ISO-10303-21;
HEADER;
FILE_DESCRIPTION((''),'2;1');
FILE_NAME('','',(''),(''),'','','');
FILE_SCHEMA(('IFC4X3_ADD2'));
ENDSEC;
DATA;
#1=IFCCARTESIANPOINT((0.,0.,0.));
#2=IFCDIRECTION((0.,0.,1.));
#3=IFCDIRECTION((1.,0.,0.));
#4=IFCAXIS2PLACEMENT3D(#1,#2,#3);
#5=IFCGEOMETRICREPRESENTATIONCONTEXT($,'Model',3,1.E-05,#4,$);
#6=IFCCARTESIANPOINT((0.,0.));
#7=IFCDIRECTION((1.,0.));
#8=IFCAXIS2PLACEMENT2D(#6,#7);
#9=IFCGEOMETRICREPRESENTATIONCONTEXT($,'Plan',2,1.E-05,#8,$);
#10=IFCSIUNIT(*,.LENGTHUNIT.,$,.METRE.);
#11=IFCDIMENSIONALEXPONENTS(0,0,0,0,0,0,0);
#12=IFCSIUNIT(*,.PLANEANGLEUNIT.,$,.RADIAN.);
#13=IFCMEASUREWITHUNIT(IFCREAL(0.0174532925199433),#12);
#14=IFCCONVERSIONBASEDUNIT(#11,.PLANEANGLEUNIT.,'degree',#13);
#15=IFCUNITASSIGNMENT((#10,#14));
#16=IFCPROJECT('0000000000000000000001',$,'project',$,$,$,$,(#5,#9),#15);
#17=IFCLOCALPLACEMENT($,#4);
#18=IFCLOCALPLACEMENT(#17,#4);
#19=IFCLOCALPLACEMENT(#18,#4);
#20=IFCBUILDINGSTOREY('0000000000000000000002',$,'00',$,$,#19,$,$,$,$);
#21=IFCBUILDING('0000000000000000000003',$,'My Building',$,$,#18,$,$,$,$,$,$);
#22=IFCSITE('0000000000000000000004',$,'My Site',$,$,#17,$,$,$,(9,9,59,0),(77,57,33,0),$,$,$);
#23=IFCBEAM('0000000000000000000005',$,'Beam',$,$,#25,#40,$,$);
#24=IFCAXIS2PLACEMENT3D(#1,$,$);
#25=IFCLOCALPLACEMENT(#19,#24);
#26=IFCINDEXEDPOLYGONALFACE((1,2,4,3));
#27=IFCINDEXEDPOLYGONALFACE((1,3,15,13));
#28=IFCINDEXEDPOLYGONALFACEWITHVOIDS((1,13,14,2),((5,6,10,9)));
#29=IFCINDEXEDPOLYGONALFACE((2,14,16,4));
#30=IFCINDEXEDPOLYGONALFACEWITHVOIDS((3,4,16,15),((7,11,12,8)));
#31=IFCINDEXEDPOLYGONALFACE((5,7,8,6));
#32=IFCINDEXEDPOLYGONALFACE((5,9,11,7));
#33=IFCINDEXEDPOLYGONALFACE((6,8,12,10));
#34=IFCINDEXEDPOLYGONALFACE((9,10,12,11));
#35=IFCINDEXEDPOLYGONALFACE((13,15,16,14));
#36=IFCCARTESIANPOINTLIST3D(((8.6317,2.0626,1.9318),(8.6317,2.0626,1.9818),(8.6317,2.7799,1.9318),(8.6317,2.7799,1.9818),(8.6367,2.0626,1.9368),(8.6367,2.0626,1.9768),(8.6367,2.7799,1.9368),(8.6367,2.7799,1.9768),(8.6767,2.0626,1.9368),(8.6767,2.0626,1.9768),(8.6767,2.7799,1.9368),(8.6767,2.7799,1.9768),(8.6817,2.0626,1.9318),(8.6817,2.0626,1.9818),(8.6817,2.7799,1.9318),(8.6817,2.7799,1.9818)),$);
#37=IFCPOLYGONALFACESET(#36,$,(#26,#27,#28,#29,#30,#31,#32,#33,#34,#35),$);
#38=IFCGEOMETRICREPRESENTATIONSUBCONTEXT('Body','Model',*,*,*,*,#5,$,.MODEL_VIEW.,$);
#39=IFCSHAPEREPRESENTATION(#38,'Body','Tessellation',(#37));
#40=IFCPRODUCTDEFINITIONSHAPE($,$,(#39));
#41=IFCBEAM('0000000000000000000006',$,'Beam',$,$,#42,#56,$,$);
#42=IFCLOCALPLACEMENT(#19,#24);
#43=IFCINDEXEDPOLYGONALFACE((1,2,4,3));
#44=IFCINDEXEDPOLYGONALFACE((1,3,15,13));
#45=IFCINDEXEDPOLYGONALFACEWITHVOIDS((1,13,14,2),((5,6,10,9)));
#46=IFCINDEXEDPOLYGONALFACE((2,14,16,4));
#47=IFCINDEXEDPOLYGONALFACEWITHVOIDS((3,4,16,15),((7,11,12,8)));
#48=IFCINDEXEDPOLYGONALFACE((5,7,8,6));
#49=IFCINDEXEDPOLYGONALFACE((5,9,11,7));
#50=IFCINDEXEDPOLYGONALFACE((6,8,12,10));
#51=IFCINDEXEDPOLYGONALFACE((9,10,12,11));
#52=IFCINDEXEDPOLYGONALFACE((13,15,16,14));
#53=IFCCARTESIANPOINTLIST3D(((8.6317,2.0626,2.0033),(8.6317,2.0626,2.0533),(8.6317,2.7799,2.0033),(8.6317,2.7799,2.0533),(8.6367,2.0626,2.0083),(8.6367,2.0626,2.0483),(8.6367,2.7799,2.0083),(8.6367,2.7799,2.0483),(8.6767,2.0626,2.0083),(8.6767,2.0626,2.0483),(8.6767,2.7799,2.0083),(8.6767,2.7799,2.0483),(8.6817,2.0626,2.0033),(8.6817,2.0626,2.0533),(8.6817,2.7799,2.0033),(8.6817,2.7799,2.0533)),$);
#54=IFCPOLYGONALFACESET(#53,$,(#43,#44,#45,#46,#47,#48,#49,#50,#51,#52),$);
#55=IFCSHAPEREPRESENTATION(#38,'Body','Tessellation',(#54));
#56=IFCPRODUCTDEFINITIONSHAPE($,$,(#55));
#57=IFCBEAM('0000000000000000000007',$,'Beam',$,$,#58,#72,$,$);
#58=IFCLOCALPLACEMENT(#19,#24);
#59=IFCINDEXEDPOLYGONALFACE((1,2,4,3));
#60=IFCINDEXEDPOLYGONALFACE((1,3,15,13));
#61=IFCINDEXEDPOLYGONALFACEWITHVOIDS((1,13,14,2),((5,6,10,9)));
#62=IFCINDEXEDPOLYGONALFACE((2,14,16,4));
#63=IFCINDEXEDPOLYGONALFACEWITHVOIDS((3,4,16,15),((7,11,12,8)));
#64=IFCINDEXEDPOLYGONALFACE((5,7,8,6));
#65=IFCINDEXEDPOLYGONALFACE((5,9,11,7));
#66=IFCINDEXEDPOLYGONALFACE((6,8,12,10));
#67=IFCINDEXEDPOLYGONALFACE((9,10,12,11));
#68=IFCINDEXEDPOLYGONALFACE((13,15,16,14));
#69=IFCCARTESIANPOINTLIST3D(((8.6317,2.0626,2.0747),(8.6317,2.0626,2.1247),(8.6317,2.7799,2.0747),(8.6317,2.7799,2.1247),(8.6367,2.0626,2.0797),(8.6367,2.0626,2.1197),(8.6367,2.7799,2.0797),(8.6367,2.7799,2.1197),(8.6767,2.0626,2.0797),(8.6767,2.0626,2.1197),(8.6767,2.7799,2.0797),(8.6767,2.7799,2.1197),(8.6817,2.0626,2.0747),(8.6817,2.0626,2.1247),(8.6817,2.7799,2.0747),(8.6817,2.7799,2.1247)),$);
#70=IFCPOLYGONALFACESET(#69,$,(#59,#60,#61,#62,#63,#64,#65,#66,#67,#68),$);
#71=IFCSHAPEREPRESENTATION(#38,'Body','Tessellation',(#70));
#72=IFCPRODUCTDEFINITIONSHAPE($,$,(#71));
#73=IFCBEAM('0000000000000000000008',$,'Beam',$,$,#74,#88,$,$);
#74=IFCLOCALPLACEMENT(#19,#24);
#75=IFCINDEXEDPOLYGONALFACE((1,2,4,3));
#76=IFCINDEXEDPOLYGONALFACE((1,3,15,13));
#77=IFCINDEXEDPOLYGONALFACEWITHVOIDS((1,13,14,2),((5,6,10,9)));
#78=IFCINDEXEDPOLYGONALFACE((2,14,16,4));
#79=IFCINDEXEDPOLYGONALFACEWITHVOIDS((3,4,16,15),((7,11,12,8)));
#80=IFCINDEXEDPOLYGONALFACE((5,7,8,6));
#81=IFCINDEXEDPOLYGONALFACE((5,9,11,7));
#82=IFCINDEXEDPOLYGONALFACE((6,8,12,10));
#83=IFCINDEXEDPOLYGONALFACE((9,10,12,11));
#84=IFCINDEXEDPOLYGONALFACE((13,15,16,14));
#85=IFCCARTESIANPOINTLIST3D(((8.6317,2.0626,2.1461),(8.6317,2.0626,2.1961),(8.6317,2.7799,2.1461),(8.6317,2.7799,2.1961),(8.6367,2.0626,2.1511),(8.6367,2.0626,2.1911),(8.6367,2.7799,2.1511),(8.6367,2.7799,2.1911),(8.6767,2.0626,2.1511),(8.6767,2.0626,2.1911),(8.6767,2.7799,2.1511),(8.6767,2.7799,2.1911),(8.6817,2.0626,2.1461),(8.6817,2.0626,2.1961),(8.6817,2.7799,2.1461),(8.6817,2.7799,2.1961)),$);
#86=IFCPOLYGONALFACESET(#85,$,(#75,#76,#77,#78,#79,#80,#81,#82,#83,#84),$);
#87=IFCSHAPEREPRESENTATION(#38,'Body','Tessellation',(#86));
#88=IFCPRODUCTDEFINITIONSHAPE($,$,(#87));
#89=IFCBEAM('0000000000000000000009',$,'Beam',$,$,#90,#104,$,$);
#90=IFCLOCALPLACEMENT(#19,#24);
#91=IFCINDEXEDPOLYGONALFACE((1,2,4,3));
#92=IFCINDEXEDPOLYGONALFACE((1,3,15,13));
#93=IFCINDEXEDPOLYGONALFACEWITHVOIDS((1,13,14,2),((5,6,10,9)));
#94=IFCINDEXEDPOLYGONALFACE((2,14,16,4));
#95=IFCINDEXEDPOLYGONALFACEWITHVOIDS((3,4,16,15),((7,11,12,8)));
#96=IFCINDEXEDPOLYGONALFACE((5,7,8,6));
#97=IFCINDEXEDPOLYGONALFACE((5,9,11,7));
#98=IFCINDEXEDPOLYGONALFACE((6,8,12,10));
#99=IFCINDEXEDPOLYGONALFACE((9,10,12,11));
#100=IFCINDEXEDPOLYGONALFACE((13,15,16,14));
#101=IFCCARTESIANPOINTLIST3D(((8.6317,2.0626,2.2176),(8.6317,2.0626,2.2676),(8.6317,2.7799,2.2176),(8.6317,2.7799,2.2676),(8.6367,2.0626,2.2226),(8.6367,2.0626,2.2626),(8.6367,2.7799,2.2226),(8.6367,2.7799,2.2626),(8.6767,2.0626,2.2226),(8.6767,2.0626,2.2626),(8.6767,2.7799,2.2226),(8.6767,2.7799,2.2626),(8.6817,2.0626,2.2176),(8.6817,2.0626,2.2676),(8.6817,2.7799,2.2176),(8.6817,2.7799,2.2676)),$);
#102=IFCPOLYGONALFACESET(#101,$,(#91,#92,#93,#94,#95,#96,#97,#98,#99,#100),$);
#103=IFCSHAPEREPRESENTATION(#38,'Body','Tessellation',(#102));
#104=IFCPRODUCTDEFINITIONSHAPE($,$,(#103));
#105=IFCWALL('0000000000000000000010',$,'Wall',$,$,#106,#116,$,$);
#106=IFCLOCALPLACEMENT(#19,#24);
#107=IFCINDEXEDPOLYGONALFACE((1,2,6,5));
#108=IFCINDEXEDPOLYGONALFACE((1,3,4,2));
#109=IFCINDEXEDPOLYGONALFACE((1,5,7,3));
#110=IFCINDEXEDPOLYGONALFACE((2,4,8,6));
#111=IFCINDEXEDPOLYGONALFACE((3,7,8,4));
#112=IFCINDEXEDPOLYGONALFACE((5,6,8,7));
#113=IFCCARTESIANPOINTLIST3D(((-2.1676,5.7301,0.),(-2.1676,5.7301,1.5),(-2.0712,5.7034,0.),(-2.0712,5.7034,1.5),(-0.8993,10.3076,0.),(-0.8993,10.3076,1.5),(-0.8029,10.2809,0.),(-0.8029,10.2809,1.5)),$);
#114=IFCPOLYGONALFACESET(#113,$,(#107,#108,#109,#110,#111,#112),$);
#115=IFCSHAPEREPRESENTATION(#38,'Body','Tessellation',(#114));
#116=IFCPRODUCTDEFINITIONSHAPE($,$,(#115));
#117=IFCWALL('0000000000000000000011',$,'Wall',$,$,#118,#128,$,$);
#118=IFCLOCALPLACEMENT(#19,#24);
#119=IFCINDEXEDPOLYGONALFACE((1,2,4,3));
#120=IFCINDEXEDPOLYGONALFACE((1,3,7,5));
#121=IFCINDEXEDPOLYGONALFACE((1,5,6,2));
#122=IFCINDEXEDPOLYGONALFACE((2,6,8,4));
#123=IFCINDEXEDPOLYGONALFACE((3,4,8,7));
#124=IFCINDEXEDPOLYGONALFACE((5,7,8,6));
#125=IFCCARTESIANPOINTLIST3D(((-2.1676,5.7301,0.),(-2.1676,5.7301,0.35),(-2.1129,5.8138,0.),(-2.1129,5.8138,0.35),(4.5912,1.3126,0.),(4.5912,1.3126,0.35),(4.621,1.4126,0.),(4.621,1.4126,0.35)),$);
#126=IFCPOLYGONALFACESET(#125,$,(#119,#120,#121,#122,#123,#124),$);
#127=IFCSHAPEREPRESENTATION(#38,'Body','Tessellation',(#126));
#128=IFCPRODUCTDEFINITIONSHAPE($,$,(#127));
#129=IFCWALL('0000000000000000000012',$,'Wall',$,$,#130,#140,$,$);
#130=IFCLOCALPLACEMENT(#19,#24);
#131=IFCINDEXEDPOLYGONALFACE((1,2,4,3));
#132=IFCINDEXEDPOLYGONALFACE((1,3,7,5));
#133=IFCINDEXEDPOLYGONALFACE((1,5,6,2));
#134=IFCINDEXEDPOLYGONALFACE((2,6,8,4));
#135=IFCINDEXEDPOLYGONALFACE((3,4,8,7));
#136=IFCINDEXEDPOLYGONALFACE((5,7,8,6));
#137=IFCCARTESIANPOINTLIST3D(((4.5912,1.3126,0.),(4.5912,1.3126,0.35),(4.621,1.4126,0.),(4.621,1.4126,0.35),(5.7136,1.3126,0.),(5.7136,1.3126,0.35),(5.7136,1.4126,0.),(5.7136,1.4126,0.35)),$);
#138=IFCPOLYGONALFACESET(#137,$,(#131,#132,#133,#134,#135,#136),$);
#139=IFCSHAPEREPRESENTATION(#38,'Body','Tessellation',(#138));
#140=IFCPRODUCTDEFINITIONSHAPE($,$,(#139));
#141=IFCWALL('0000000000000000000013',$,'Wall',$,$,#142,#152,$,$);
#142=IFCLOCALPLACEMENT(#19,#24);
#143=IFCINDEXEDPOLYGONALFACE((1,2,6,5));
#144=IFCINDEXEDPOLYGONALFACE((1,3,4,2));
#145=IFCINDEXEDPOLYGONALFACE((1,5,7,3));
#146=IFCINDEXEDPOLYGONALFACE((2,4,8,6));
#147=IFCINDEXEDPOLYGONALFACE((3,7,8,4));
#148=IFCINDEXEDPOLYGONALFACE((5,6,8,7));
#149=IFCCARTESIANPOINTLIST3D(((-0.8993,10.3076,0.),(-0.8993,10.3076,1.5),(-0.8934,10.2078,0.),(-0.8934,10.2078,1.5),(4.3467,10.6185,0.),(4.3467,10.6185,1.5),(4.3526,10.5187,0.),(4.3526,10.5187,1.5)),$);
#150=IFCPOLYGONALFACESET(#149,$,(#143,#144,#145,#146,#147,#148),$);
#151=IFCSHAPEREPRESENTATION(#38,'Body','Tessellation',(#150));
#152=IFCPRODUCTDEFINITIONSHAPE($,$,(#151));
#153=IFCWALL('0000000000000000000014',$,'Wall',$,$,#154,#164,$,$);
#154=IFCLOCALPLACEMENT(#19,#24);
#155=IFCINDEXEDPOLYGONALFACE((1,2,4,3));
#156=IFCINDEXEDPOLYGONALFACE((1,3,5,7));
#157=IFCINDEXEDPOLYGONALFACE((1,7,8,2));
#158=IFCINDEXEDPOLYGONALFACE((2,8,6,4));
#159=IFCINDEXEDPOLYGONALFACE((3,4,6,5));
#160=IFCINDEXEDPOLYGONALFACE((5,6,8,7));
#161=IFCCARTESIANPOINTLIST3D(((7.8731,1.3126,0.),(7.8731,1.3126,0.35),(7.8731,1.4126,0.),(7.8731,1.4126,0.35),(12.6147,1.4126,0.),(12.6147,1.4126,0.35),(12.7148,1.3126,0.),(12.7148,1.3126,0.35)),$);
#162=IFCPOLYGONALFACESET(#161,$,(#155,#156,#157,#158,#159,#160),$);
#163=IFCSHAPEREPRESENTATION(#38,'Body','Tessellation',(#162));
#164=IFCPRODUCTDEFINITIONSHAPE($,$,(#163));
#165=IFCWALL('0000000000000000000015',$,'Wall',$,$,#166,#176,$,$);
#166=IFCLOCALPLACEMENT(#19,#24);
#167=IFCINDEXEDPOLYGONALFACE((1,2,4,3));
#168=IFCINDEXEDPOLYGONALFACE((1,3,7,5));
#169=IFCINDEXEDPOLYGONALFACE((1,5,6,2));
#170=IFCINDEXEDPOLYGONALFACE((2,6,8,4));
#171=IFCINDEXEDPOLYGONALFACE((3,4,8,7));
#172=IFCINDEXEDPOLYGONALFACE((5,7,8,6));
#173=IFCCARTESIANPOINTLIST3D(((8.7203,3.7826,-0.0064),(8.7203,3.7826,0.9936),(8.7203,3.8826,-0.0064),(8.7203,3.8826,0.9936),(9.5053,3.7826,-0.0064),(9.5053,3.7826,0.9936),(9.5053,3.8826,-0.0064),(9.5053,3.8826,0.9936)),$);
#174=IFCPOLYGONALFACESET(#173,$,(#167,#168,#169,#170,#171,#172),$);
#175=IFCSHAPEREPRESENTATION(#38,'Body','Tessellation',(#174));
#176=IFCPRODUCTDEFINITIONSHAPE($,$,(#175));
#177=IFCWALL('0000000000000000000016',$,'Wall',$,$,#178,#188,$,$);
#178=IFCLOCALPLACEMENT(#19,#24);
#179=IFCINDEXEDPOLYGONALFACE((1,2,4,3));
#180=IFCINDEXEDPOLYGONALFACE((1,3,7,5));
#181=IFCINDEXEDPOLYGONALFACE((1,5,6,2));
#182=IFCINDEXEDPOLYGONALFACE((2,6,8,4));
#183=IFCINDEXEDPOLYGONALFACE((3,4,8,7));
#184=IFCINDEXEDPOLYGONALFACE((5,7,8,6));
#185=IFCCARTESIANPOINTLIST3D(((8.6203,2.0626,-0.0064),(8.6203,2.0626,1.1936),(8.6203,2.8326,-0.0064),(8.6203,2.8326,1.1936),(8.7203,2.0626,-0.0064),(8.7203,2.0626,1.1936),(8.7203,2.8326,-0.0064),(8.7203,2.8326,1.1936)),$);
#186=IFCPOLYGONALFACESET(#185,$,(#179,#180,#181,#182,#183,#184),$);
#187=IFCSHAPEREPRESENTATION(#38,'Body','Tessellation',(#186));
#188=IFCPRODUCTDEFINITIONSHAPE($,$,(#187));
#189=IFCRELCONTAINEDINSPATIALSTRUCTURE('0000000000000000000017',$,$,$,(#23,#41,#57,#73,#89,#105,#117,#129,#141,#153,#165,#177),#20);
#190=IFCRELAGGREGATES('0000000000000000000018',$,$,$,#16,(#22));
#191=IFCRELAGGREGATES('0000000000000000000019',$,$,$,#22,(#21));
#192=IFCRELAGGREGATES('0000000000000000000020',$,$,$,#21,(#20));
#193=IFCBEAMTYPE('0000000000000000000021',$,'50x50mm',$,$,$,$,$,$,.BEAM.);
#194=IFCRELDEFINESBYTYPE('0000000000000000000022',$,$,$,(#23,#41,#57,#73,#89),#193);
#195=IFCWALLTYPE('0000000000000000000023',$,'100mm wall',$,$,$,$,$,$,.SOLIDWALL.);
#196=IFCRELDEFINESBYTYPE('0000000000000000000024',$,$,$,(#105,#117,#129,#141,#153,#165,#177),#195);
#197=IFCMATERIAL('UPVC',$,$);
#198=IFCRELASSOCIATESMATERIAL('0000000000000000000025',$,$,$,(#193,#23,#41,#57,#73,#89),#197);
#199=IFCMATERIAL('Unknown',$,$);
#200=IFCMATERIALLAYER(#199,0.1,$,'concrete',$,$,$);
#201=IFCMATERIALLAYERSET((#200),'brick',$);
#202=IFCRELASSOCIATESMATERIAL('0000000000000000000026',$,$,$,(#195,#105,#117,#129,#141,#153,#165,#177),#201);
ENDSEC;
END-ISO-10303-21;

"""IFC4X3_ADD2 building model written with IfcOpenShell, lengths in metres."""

from ifc_helpers import new_model, entity, si_unit, converted_unit, frame, origin_with_axes, origin_2d_with_axis, place, context, subcontext, project, spatial, line, indexed_curve, hollow_rectangle, outline, extrude, material, layer, layer_set, layer_usage, material_profile, profile_set, profile_usage, type_object, element, save


model = new_model("IFC4X3_ADD2")

# Units and contexts
model_context = context("Model", 3, precision=1e-05, world=origin_with_axes())
plan_context = context("Plan", 2, precision=1e-05, world=origin_2d_with_axis())
body_context = subcontext(model_context, "Body", "Model", "MODEL_VIEW")
ifc_project = project(units=[si_unit("LENGTHUNIT", "METRE"), converted_unit("PLANEANGLEUNIT", "degree", entity("IfcReal", 0.0174532925199433), si_unit("PLANEANGLEUNIT", "RADIAN"), dimensions=[0, 0, 0, 0, 0, 0, 0])], contexts=[model_context, plan_context])

# Site, building, storey
site_placement = place(None, origin_with_axes())
site = spatial("IfcSite", under=ifc_project, at=site_placement, Name="My Site", RefLatitude=(9, 9, 59, 0), RefLongitude=(77, 57, 33, 0))
building_placement = place(site_placement, origin_with_axes())
building = spatial("IfcBuilding", under=site, at=building_placement, Name="My Building")
storey_placement = place(building_placement, origin_with_axes())
storey = spatial("IfcBuildingStorey", under=building, at=storey_placement, Name="00")

# Beams
ifc_material_1 = material(Name="UPVC")
ifc_material_profile_1 = material_profile(ifc_material_1, hollow_rectangle(XDim=0.05, YDim=0.05, WallThickness=0.005))
ifc_profile_set_1 = profile_set([ifc_material_profile_1])
beam_type = type_object("IfcBeamType", Name="50x50mm", PredefinedType="BEAM", material=ifc_profile_set_1)
ifc_profile_usage_1 = profile_usage(ifc_profile_set_1, cardinal=5)
beam_1_placement = place(storey_placement, frame((8.6567, 2.0626, 1.9568), z_axis=(0.0, 1.0, 0.000001), x_axis=(-1.0, 0.0, 0.0)))
element("IfcBeam", 1, at=beam_1_placement, inside=storey, type_object=beam_type, material=ifc_profile_usage_1, Name="Beam", context=body_context, shape_type="SweptSolid", body=[
    extrude(hollow_rectangle(XDim=0.05, YDim=0.05, WallThickness=0.005), origin_with_axes(), (0.0, 0.0, 1.0), 0.7174),
])
ifc_profile_usage_2 = profile_usage(ifc_profile_set_1, cardinal=5)
beam_2_placement = place(storey_placement, frame((8.6567, 2.0626, 2.0283), z_axis=(0.0, 1.0, 0.000001), x_axis=(-1.0, 0.0, 0.0)))
element("IfcBeam", 2, at=beam_2_placement, inside=storey, type_object=beam_type, material=ifc_profile_usage_2, Name="Beam", context=body_context, shape_type="SweptSolid", body=[
    extrude(hollow_rectangle(XDim=0.05, YDim=0.05, WallThickness=0.005), origin_with_axes(), (0.0, 0.0, 1.0), 0.7174),
])
ifc_profile_usage_3 = profile_usage(ifc_profile_set_1, cardinal=5)
beam_3_placement = place(storey_placement, frame((8.6567, 2.0626, 2.0997), z_axis=(0.0, 1.0, 0.000001), x_axis=(-1.0, 0.0, 0.0)))
element("IfcBeam", 3, at=beam_3_placement, inside=storey, type_object=beam_type, material=ifc_profile_usage_3, Name="Beam", context=body_context, shape_type="SweptSolid", body=[
    extrude(hollow_rectangle(XDim=0.05, YDim=0.05, WallThickness=0.005), origin_with_axes(), (0.0, 0.0, 1.0), 0.7174),
])
ifc_profile_usage_4 = profile_usage(ifc_profile_set_1, cardinal=5)
beam_4_placement = place(storey_placement, frame((8.6567, 2.0626, 2.1711), z_axis=(0.0, 1.0, 0.000001), x_axis=(-1.0, 0.0, 0.0)))
element("IfcBeam", 4, at=beam_4_placement, inside=storey, type_object=beam_type, material=ifc_profile_usage_4, Name="Beam", context=body_context, shape_type="SweptSolid", body=[
    extrude(hollow_rectangle(XDim=0.05, YDim=0.05, WallThickness=0.005), origin_with_axes(), (0.0, 0.0, 1.0), 0.7174),
])
ifc_profile_usage_5 = profile_usage(ifc_profile_set_1, cardinal=5)
beam_5_placement = place(storey_placement, frame((8.6567, 2.0626, 2.2426), z_axis=(0.0, 1.0, 0.000001), x_axis=(-1.0, 0.0, 0.0)))
element("IfcBeam", 5, at=beam_5_placement, inside=storey, type_object=beam_type, material=ifc_profile_usage_5, Name="Beam", context=body_context, shape_type="SweptSolid", body=[
    extrude(hollow_rectangle(XDim=0.05, YDim=0.05, WallThickness=0.005), origin_with_axes(), (0.0, 0.0, 1.0), 0.7174),
])

# Walls
ifc_material_2 = material(Name="Unknown")
ifc_layer = layer(ifc_material_2, 0.1, Name="concrete")
ifc_layer_set = layer_set([ifc_layer], Name="brick")
ifc_layer_usage_1 = layer_usage(ifc_layer_set, "AXIS2", "POSITIVE", 0.0)
wall_type = type_object("IfcWallType", Name="100mm wall", PredefinedType="SOLIDWALL", material=ifc_layer_set)
wall_1_placement = place(storey_placement, frame((-0.8993, 10.3076, 0.0), z_axis=(0.0, 0.0, 1.0), x_axis=(-0.267012, -0.963693, 0.0)))
element("IfcWall", 6, at=wall_1_placement, inside=storey, type_object=wall_type, material=ifc_layer_usage_1, Name="Wall", context=body_context, shape_type="SweptSolid", body=[
    extrude(outline(indexed_curve([(0.0, 0.0), (0.0, 0.1), (4.75, 0.1), (4.75, 0.0)], segments=[line(1, 2, 3, 4, 1)])), origin_with_axes(), (0.0, 0.0, 1.0), 1.5),
])
ifc_layer_usage_2 = layer_usage(ifc_layer_set, "AXIS2", "POSITIVE", 0.0)
wall_2_placement = place(storey_placement, frame((-2.1676, 5.7301, 0.0), z_axis=(0.0, 0.0, 1.0), x_axis=(0.837068, -0.547098, 0.0)))
element("IfcWall", 7, at=wall_2_placement, inside=storey, type_object=wall_type, material=ifc_layer_usage_2, Name="Wall", context=body_context, shape_type="SweptSolid", body=[
    extrude(outline(indexed_curve([(0.0, 0.0), (0.0, 0.1), (8.0446, 0.1), (8.0744, 0.0)], segments=[line(1, 2, 3, 4, 1)])), origin_with_axes(), (0.0, 0.0, 1.0), 0.35),
])
ifc_layer_usage_3 = layer_usage(ifc_layer_set, "AXIS2", "POSITIVE", 0.0)
wall_3_placement = place(storey_placement, frame((4.5912, 1.3126, 0.0), z_axis=(0.0, 0.0, 1.0), x_axis=(1.0, 0.0, 0.0)))
element("IfcWall", 8, at=wall_3_placement, inside=storey, type_object=wall_type, material=ifc_layer_usage_3, Name="Wall", context=body_context, shape_type="SweptSolid", body=[
    extrude(outline(indexed_curve([(0.0, 0.0), (0.0298, 0.1), (1.1224, 0.1), (1.1224, 0.0)], segments=[line(1, 2, 3, 4, 1)])), origin_with_axes(), (0.0, 0.0, 1.0), 0.35),
])
ifc_layer_usage_4 = layer_usage(ifc_layer_set, "AXIS2", "POSITIVE", 0.0)
wall_4_placement = place(storey_placement, frame((4.3467, 10.6185, 0.0), z_axis=(0.0, 0.0, 1.0), x_axis=(-0.998249, -0.059157, 0.0)))
element("IfcWall", 9, at=wall_4_placement, inside=storey, type_object=wall_type, material=ifc_layer_usage_4, Name="Wall", context=body_context, shape_type="SweptSolid", body=[
    extrude(outline(indexed_curve([(0.0, 0.0), (0.0, 0.1), (5.2552, 0.1), (5.2552, 0.0)], segments=[line(1, 2, 3, 4, 1)])), origin_with_axes(), (0.0, 0.0, 1.0), 1.5),
])
ifc_layer_usage_5 = layer_usage(ifc_layer_set, "AXIS2", "POSITIVE", 0.0)
wall_5_placement = place(storey_placement, frame((7.8731, 1.3126, 0.0), z_axis=(0.0, 0.0, 1.0), x_axis=(1.0, 0.0, 0.0)))
element("IfcWall", 10, at=wall_5_placement, inside=storey, type_object=wall_type, material=ifc_layer_usage_5, Name="Wall", context=body_context, shape_type="SweptSolid", body=[
    extrude(outline(indexed_curve([(0.0, 0.0), (0.0, 0.1), (4.7416, 0.1), (4.8417, 0.0)], segments=[line(1, 2, 3, 4, 1)])), origin_with_axes(), (0.0, 0.0, 1.0), 0.35),
])
ifc_layer_usage_6 = layer_usage(ifc_layer_set, "AXIS2", "POSITIVE", 0.0)
wall_6_placement = place(storey_placement, frame((8.7203, 3.7826, -0.0064), z_axis=(0.0, 0.0, 1.0), x_axis=(1.0, 0.0, 0.0)))
element("IfcWall", 11, at=wall_6_placement, inside=storey, type_object=wall_type, material=ifc_layer_usage_6, Name="Wall", context=body_context, shape_type="SweptSolid", body=[
    extrude(outline(indexed_curve([(0.0, 0.0), (0.0, 0.1), (0.785, 0.1), (0.785, 0.0)], segments=[line(1, 2, 3, 4, 1)])), origin_with_axes(), (0.0, 0.0, 1.0), 1.0),
])
ifc_layer_usage_7 = layer_usage(ifc_layer_set, "AXIS2", "POSITIVE", 0.0)
wall_7_placement = place(storey_placement, frame((8.7203, 2.0626, -0.0064), z_axis=(0.0, 0.0, 1.0), x_axis=(0.0, 1.0, 0.0)))
element("IfcWall", 12, at=wall_7_placement, inside=storey, type_object=wall_type, material=ifc_layer_usage_7, Name="Wall", context=body_context, shape_type="SweptSolid", body=[
    extrude(outline(indexed_curve([(0.0, 0.0), (0.0, 0.1), (0.77, 0.1), (0.77, 0.0)], segments=[line(1, 2, 3, 4, 1)])), origin_with_axes(), (0.0, 0.0, 1.0), 1.2),
])

save(model, "model.ifc")
